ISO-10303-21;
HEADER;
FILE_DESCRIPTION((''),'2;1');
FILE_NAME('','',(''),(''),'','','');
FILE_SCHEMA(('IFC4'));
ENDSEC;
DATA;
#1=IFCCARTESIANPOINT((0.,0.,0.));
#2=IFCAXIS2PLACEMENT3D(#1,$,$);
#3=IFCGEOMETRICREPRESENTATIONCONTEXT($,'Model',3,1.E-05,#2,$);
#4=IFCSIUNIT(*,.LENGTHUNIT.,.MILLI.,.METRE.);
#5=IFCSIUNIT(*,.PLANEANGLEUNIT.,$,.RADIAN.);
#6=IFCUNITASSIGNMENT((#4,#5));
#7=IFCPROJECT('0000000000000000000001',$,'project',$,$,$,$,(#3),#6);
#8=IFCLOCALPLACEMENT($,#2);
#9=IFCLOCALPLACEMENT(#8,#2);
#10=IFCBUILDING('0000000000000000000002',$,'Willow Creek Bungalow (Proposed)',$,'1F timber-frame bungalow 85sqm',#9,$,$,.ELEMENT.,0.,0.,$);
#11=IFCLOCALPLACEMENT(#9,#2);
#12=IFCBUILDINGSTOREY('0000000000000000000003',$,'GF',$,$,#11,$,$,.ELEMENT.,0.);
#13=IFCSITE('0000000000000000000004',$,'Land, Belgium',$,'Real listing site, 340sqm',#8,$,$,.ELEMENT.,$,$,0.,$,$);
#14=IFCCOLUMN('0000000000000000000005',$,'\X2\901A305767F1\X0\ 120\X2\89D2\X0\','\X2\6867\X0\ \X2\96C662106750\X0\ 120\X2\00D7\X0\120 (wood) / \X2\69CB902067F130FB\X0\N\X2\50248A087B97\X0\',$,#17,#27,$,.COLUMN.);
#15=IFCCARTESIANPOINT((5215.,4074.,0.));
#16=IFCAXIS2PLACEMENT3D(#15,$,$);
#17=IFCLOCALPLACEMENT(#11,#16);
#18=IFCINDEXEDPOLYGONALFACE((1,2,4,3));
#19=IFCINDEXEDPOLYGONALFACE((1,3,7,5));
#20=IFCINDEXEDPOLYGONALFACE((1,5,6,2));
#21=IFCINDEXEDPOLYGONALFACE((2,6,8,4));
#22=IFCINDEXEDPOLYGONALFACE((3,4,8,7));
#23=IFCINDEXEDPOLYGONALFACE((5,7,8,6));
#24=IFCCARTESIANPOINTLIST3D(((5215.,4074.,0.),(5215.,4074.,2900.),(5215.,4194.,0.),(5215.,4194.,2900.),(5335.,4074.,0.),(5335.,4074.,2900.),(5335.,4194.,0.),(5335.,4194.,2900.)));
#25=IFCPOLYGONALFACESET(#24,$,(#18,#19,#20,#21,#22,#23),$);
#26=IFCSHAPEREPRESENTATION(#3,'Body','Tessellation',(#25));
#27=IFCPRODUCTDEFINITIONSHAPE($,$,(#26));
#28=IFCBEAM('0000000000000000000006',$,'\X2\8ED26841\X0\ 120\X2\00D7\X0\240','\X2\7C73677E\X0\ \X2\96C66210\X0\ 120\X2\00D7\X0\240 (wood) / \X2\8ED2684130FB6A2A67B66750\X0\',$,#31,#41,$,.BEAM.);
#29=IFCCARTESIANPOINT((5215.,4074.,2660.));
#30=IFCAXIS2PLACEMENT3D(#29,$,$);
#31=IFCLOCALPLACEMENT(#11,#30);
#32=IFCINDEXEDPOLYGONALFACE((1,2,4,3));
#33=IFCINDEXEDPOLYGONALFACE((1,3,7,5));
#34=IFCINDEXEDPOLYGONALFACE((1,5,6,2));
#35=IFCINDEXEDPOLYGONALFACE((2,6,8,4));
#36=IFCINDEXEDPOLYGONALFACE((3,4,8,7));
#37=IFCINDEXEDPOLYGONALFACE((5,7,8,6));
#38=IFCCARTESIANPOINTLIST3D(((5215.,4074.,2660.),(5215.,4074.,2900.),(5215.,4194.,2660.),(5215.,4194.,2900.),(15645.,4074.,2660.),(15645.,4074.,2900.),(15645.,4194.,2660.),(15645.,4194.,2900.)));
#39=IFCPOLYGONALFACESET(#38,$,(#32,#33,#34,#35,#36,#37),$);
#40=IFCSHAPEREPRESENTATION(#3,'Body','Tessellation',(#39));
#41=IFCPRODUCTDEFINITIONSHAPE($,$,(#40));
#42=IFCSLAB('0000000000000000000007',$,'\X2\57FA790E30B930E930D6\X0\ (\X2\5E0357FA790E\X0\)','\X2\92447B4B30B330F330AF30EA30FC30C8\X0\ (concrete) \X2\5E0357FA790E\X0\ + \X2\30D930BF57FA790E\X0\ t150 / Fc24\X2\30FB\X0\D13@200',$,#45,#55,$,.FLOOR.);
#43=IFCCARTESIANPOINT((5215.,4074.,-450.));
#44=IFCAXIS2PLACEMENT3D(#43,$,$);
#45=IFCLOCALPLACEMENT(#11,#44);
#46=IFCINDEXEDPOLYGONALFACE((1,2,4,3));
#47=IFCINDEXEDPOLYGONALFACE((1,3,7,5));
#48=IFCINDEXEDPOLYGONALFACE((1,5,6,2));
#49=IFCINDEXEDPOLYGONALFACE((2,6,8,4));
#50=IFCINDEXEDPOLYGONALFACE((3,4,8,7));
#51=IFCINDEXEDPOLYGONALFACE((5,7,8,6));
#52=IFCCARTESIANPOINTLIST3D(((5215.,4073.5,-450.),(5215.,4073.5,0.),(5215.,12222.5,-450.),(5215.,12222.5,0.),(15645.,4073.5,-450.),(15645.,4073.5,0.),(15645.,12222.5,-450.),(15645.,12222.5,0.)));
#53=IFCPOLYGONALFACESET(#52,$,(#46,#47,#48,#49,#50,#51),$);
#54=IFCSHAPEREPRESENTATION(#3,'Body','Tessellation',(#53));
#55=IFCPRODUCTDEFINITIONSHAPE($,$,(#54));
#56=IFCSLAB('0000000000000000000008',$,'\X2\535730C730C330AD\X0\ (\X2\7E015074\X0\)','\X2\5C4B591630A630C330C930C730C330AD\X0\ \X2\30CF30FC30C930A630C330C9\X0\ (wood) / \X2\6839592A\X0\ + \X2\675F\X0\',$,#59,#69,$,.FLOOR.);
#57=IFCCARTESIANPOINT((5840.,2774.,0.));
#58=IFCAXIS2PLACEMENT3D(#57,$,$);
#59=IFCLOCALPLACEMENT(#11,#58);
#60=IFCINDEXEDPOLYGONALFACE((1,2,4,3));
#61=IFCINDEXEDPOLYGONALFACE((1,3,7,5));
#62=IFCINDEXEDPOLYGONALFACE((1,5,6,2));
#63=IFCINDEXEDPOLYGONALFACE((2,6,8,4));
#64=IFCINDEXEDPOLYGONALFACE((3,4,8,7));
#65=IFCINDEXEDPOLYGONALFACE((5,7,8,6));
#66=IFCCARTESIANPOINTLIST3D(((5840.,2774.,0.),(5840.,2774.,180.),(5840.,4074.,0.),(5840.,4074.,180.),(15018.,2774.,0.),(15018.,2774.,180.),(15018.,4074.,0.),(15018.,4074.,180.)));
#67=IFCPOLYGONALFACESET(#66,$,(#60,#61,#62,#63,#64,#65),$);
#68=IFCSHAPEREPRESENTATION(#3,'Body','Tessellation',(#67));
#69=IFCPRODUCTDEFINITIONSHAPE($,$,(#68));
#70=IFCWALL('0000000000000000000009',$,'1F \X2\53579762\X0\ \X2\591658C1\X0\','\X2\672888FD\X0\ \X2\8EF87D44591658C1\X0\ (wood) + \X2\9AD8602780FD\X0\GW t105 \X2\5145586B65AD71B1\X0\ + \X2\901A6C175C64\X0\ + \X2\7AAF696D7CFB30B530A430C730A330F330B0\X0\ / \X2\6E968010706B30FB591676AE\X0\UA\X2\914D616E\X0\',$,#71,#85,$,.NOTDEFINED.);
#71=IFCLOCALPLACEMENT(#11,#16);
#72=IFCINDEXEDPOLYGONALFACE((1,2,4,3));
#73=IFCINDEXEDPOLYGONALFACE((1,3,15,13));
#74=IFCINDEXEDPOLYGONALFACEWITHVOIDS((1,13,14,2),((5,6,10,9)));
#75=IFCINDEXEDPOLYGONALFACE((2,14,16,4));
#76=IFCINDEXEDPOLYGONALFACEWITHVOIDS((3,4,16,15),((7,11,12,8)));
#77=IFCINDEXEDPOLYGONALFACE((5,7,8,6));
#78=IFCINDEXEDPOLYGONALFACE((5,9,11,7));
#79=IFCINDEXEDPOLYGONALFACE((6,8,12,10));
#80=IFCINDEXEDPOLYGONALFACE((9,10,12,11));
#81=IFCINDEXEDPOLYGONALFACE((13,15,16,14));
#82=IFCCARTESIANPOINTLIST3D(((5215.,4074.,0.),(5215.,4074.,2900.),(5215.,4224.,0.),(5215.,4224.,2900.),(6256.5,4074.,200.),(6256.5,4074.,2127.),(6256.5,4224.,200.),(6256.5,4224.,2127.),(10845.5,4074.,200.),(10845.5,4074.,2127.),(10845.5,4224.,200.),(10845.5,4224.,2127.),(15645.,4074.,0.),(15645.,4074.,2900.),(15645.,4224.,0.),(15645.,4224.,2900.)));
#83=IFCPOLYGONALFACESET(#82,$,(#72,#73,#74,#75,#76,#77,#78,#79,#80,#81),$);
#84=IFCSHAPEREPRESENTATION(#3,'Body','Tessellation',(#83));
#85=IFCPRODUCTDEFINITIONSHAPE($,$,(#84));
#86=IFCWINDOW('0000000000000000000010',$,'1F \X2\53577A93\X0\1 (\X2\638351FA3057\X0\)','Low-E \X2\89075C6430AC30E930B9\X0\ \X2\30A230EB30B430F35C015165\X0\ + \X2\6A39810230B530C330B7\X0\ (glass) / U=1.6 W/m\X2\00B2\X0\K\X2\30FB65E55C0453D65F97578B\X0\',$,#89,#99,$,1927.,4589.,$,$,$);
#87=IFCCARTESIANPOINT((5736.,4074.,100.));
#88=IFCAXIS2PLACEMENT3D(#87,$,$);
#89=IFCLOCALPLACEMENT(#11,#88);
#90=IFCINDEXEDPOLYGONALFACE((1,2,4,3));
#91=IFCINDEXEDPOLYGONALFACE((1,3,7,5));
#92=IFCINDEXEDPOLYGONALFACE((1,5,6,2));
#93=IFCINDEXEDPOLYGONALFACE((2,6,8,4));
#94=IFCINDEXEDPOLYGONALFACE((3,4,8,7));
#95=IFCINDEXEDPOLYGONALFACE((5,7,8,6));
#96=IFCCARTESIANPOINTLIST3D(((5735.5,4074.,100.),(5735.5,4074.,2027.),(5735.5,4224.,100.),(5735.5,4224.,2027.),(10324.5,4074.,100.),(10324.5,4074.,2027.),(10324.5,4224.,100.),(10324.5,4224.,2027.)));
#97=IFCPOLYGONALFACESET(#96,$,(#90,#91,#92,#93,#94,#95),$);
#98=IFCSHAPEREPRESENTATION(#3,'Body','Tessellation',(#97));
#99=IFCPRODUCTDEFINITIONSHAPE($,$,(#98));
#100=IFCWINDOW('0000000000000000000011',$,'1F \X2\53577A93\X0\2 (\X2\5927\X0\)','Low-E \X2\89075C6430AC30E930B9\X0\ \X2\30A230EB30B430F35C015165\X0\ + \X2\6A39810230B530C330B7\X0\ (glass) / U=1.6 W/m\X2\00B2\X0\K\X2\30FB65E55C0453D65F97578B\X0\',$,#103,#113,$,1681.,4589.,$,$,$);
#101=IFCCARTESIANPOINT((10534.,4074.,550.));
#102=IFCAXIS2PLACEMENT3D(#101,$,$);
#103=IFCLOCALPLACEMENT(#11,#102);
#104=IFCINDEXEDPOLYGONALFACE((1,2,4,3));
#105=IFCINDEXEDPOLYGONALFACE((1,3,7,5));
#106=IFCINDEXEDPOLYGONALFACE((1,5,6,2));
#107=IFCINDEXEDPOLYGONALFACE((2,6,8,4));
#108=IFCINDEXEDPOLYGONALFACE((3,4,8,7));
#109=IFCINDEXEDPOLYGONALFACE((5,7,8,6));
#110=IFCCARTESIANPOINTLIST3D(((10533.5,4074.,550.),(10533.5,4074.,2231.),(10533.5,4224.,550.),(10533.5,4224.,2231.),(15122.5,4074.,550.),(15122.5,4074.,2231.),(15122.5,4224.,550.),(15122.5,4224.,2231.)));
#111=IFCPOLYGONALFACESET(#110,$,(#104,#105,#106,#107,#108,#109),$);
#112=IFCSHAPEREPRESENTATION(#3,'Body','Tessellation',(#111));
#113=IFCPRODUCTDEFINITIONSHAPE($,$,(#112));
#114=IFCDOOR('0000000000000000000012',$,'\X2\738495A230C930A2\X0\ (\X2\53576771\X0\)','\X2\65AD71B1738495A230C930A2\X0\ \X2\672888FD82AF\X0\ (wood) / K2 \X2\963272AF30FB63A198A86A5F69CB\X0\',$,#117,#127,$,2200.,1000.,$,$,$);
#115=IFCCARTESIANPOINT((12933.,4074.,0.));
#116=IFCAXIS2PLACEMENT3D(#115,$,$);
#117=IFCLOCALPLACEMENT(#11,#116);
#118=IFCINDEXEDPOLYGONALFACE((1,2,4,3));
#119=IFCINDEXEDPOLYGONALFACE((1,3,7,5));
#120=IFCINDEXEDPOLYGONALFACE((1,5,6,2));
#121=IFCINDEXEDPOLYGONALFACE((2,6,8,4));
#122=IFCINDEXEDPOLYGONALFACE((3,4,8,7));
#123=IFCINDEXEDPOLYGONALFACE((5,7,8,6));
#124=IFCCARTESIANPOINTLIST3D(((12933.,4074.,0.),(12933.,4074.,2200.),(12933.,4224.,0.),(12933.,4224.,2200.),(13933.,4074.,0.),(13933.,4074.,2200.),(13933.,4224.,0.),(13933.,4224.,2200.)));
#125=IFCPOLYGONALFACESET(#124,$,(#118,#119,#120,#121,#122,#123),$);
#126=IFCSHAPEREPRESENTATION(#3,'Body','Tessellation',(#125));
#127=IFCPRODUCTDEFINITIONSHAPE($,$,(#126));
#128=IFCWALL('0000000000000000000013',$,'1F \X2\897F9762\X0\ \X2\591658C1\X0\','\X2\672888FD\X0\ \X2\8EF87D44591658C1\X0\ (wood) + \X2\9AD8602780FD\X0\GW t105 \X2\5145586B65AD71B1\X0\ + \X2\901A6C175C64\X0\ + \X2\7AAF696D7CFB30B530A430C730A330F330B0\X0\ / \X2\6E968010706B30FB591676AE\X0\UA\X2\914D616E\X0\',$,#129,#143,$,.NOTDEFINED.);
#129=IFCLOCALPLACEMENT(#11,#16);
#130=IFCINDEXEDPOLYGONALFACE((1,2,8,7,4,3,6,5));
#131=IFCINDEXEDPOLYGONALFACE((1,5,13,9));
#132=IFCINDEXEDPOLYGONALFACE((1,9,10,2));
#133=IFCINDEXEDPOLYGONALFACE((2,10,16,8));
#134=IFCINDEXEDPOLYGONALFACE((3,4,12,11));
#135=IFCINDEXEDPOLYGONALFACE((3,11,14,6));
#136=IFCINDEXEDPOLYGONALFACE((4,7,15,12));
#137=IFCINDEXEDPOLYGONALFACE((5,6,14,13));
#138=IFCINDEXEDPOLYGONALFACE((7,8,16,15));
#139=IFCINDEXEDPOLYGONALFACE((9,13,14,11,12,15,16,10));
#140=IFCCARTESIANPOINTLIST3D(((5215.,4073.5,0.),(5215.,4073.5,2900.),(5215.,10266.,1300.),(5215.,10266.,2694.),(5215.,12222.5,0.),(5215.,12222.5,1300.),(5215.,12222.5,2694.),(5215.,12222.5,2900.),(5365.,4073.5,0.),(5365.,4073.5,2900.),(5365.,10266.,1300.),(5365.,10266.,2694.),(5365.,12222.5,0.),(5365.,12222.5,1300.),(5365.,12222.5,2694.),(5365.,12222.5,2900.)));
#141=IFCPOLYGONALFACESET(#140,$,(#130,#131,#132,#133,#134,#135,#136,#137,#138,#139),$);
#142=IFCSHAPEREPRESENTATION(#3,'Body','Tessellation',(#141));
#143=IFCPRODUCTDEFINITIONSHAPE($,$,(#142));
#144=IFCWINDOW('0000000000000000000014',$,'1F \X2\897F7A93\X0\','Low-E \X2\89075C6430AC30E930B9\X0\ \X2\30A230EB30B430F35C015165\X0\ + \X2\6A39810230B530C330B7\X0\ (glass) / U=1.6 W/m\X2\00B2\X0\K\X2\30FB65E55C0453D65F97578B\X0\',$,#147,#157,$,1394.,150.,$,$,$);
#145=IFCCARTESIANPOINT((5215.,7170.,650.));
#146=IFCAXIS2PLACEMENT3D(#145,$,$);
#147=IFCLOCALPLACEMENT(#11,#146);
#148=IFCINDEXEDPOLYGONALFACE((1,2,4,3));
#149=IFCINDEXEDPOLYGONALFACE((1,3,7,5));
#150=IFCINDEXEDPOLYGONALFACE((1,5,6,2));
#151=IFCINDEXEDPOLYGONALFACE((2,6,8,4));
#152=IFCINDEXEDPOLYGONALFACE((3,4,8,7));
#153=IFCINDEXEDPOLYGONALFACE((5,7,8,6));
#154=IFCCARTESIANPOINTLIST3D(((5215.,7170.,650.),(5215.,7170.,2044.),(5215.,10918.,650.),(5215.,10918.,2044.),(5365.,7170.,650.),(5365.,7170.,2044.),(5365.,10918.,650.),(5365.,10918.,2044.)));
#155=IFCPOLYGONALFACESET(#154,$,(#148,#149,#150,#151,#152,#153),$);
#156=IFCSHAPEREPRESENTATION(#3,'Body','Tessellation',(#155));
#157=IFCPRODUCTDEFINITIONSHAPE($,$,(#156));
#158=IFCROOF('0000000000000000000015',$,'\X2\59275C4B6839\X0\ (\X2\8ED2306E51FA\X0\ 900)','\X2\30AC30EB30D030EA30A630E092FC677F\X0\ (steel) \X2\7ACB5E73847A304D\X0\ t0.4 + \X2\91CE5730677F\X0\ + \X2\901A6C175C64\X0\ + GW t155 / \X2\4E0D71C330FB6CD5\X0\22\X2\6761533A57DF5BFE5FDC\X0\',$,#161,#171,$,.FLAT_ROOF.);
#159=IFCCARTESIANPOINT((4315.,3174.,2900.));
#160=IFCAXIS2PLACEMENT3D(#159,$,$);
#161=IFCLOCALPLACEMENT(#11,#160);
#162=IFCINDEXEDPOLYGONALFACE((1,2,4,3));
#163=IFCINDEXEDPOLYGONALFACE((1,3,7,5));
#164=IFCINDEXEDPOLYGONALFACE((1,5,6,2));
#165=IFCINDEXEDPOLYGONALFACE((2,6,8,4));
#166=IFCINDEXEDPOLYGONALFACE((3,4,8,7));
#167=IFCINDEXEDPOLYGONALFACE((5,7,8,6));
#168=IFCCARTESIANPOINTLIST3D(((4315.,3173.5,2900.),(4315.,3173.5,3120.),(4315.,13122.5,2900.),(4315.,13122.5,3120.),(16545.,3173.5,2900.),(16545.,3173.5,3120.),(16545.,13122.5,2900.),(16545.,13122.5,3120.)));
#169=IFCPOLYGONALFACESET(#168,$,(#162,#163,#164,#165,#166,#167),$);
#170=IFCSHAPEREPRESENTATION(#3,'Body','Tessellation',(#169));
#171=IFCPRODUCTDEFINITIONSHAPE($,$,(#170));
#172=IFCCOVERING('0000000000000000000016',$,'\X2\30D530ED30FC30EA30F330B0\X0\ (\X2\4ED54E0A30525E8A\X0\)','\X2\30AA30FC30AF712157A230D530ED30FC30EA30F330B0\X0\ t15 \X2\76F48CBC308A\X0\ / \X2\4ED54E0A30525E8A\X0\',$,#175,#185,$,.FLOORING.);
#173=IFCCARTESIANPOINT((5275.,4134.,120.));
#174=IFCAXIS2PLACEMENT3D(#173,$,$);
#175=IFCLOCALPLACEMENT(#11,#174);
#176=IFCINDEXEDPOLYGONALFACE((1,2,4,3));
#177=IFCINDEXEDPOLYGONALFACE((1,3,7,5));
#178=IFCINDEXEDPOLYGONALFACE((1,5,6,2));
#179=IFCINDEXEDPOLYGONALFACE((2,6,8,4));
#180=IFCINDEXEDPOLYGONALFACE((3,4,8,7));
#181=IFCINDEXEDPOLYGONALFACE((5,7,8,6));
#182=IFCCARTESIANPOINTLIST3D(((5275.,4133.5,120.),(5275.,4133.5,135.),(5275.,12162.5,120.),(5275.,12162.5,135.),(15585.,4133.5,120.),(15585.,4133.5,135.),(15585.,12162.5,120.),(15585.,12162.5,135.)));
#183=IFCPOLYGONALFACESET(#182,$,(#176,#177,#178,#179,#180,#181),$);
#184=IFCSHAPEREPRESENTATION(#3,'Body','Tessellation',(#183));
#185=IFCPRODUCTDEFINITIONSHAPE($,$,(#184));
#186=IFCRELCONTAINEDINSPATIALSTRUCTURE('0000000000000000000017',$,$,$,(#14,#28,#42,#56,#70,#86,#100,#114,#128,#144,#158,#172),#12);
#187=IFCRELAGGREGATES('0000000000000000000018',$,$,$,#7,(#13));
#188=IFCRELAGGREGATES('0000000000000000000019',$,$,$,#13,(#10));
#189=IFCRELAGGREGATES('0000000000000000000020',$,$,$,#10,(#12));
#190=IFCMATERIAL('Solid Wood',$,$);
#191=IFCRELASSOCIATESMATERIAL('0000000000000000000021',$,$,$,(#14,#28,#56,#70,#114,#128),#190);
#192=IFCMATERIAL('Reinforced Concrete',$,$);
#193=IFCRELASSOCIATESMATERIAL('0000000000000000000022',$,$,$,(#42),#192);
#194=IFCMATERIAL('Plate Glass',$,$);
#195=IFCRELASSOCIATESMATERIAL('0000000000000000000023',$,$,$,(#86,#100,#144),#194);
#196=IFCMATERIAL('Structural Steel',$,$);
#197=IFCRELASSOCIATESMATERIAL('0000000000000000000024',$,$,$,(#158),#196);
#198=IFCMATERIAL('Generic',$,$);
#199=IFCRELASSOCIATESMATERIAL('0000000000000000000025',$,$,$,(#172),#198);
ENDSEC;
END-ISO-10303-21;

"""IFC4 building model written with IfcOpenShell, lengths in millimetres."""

from ifc_helpers import new_model, si_unit, frame, frame_2d, origin, place, context, project, spatial, rectangle, extrude, material, element, fill, save


model = new_model("IFC4")

# Units and contexts
model_context = context("Model", 3, precision=1e-05, world=origin())
ifc_project = project(units=[si_unit("LENGTHUNIT", "METRE", prefix="MILLI"), si_unit("PLANEANGLEUNIT", "RADIAN")], contexts=[model_context])

# Site, building, storey
site_placement = place(None, origin())
site = spatial("IfcSite", under=ifc_project, at=site_placement, Name="Land, Belgium", ObjectType="Real listing site, 340sqm", CompositionType="ELEMENT", RefElevation=0.0)
building_placement = place(site_placement, origin())
building = spatial("IfcBuilding", under=site, at=building_placement, Name="Willow Creek Bungalow (Proposed)", ObjectType="1F timber-frame bungalow 85sqm", CompositionType="ELEMENT", ElevationOfRefHeight=0.0, ElevationOfTerrain=0.0)
storey_placement = place(building_placement, origin())
storey = spatial("IfcBuildingStorey", under=building, at=storey_placement, Name="GF", CompositionType="ELEMENT", Elevation=0.0)

# Column
ifc_material_1 = material(Name="Solid Wood")
column_1_placement = place(storey_placement, frame((5215.0, 4074.0, 0.0)))
element("IfcColumn", 1, at=column_1_placement, inside=storey, material=ifc_material_1, Name="通し柱 120角", Description="桧 集成材 120×120 (wood) / 構造柱・N値計算", PredefinedType="COLUMN", context=model_context, shape_type="SweptSolid", body=[
    extrude(rectangle(XDim=120.0, YDim=120.0, at=frame_2d((60.0, 60.0))), frame((5215.0, 4074.0, 0.0)), (0.0, 0.0, 1.0), 2900.0),
])

# Beam
beam_1_placement = place(storey_placement, frame((5215.0, 4074.0, 2660.0)))
element("IfcBeam", 2, at=beam_1_placement, inside=storey, material=ifc_material_1, Name="軒桁 120×240", Description="米松 集成 120×240 (wood) / 軒桁・横架材", PredefinedType="BEAM", context=model_context, shape_type="SweptSolid", body=[
    extrude(rectangle(XDim=10430.0, YDim=120.0, at=frame_2d((5215.0, 60.0))), frame((5215.0, 4074.0, 2660.0)), (0.0, 0.0, 1.0), 240.0),
])

# Slabs
ifc_material_2 = material(Name="Reinforced Concrete")
slab_1_placement = place(storey_placement, frame((5215.0, 4074.0, -450.0)))
element("IfcSlab", 3, at=slab_1_placement, inside=storey, material=ifc_material_2, Name="基礎スラブ (布基礎)", Description="鉄筋コンクリート (concrete) 布基礎 + ベタ基礎 t150 / Fc24・D13@200", PredefinedType="FLOOR", context=model_context, shape_type="SweptSolid", body=[
    extrude(rectangle(XDim=10430.0, YDim=8149.0, at=frame_2d((5215.0, 4074.0))), frame((5215.0, 4074.0, -450.0)), (0.0, 0.0, 1.0), 450.0),
])
slab_2_placement = place(storey_placement, frame((5840.0, 2774.0, 0.0)))
element("IfcSlab", 4, at=slab_2_placement, inside=storey, material=ifc_material_1, Name="南デッキ (縁側)", Description="屋外ウッドデッキ ハードウッド (wood) / 根太 + 束", PredefinedType="FLOOR", context=model_context, shape_type="SweptSolid", body=[
    extrude(rectangle(XDim=9178.0, YDim=1300.0, at=frame_2d((4589.0, 650.0))), frame((5840.0, 2774.0, 0.0)), (0.0, 0.0, 1.0), 180.0),
])

# Wall, openings, windows, door
wall_1_placement = place(storey_placement, frame((5215.0, 4074.0, 0.0)))
wall_1 = element("IfcWall", 5, at=wall_1_placement, inside=storey, material=ifc_material_1, Name="1F 南面 外壁", Description="木製 軸組外壁 (wood) + 高性能GW t105 充填断熱 + 通気層 + 窯業系サイディング / 準耐火・外皮UA配慮", PredefinedType="NOTDEFINED", context=model_context, shape_type="SweptSolid", body=[
    extrude(rectangle(XDim=10430.0, YDim=150.0, at=frame_2d((5215.0, 75.0))), frame((5215.0, 4074.0, 0.0)), (0.0, 0.0, 1.0), 2900.0),
])
opening_1_placement = place(storey_placement, frame((5736.0, 4074.0, 100.0)))
opening_1 = element("IfcOpeningElement", 6, at=opening_1_placement, cuts=wall_1, PredefinedType="NOTDEFINED", context=model_context, shape_type="SweptSolid", body=[
    extrude(rectangle(XDim=4589.0, YDim=150.0, at=frame_2d((2294.0, 75.0))), frame((5736.0, 4074.0, 100.0)), (0.0, 0.0, 1.0), 1927.0),
])
opening_2_placement = place(storey_placement, frame((10534.0, 4074.0, 550.0)))
opening_2 = element("IfcOpeningElement", 7, at=opening_2_placement, cuts=wall_1, PredefinedType="NOTDEFINED", context=model_context, shape_type="SweptSolid", body=[
    extrude(rectangle(XDim=4589.0, YDim=150.0, at=frame_2d((2294.0, 75.0))), frame((10534.0, 4074.0, 550.0)), (0.0, 0.0, 1.0), 1681.0),
])
opening_3_placement = place(storey_placement, frame((12933.0, 4074.0, 0.0)))
opening_3 = element("IfcOpeningElement", 8, at=opening_3_placement, cuts=wall_1, PredefinedType="NOTDEFINED", context=model_context, shape_type="SweptSolid", body=[
    extrude(rectangle(XDim=1000.0, YDim=150.0, at=frame_2d((500.0, 75.0))), frame((12933.0, 4074.0, 0.0)), (0.0, 0.0, 1.0), 2200.0),
])
ifc_material_3 = material(Name="Plate Glass")
window_1_placement = place(storey_placement, frame((5736.0, 4074.0, 100.0)))
window_1 = element("IfcWindow", 9, at=window_1_placement, inside=storey, material=ifc_material_3, Name="1F 南窓1 (掃出し)", Description="Low-E 複層ガラス アルゴン封入 + 樹脂サッシ (glass) / U=1.6 W/m²K・日射取得型", OverallHeight=1927.0, OverallWidth=4589.0, context=model_context, shape_type="SweptSolid", body=[
    extrude(rectangle(XDim=4589.0, YDim=150.0, at=frame_2d((2294.0, 75.0))), frame((5736.0, 4074.0, 100.0)), (0.0, 0.0, 1.0), 1927.0),
])
fill(opening_1, window_1)
window_2_placement = place(storey_placement, frame((10534.0, 4074.0, 550.0)))
window_2 = element("IfcWindow", 10, at=window_2_placement, inside=storey, material=ifc_material_3, Name="1F 南窓2 (大)", Description="Low-E 複層ガラス アルゴン封入 + 樹脂サッシ (glass) / U=1.6 W/m²K・日射取得型", OverallHeight=1681.0, OverallWidth=4589.0, context=model_context, shape_type="SweptSolid", body=[
    extrude(rectangle(XDim=4589.0, YDim=150.0, at=frame_2d((2294.0, 75.0))), frame((10534.0, 4074.0, 550.0)), (0.0, 0.0, 1.0), 1681.0),
])
fill(opening_2, window_2)
door_placement = place(storey_placement, frame((12933.0, 4074.0, 0.0)))
door = element("IfcDoor", 11, at=door_placement, inside=storey, material=ifc_material_1, Name="玄関ドア (南東)", Description="断熱玄関ドア 木製芯 (wood) / K2 防犯・採風機構", OverallHeight=2200.0, OverallWidth=1000.0, context=model_context, shape_type="SweptSolid", body=[
    extrude(rectangle(XDim=1000.0, YDim=150.0, at=frame_2d((500.0, 75.0))), frame((12933.0, 4074.0, 0.0)), (0.0, 0.0, 1.0), 2200.0),
])
fill(opening_3, door)

# Wall, opening, window
wall_2_placement = place(storey_placement, frame((5215.0, 4074.0, 0.0)))
wall_2 = element("IfcWall", 12, at=wall_2_placement, inside=storey, material=ifc_material_1, Name="1F 西面 外壁", Description="木製 軸組外壁 (wood) + 高性能GW t105 充填断熱 + 通気層 + 窯業系サイディング / 準耐火・外皮UA配慮", PredefinedType="NOTDEFINED", context=model_context, shape_type="SweptSolid", body=[
    extrude(rectangle(XDim=150.0, YDim=8149.0, at=frame_2d((75.0, 4074.0))), frame((5215.0, 4074.0, 0.0)), (0.0, 0.0, 1.0), 2900.0),
])
opening_4_placement = place(storey_placement, frame((5215.0, 7170.0, 650.0)))
opening_4 = element("IfcOpeningElement", 13, at=opening_4_placement, cuts=wall_2, PredefinedType="NOTDEFINED", context=model_context, shape_type="SweptSolid", body=[
    extrude(rectangle(XDim=150.0, YDim=3748.0, at=frame_2d((75.0, 1874.0))), frame((5215.0, 7170.0, 650.0)), (0.0, 0.0, 1.0), 1394.0),
])
window_3_placement = place(storey_placement, frame((5215.0, 7170.0, 650.0)))
window_3 = element("IfcWindow", 14, at=window_3_placement, inside=storey, material=ifc_material_3, Name="1F 西窓", Description="Low-E 複層ガラス アルゴン封入 + 樹脂サッシ (glass) / U=1.6 W/m²K・日射取得型", OverallHeight=1394.0, OverallWidth=150.0, context=model_context, shape_type="SweptSolid", body=[
    extrude(rectangle(XDim=150.0, YDim=3748.0, at=frame_2d((75.0, 1874.0))), frame((5215.0, 7170.0, 650.0)), (0.0, 0.0, 1.0), 1394.0),
])
fill(opening_4, window_3)

# Roof
ifc_material_4 = material(Name="Structural Steel")
roof_placement = place(storey_placement, frame((4315.0, 3174.0, 2900.0)))
element("IfcRoof", 15, at=roof_placement, inside=storey, material=ifc_material_4, Name="大屋根 (軒の出 900)", Description="ガルバリウム鋼板 (steel) 立平葺き t0.4 + 野地板 + 通気層 + GW t155 / 不燃・法22条区域対応", PredefinedType="FLAT_ROOF", context=model_context, shape_type="SweptSolid", body=[
    extrude(rectangle(XDim=12230.0, YDim=9949.0, at=frame_2d((6115.0, 4974.0))), frame((4315.0, 3174.0, 2900.0)), (0.0, 0.0, 1.0), 220.0),
])

# Covering
ifc_material_5 = material(Name="Generic")
covering_1_placement = place(storey_placement, frame((5275.0, 4134.0, 120.0)))
element("IfcCovering", 16, at=covering_1_placement, inside=storey, material=ifc_material_5, Name="フローリング (仕上げ床)", Description="オーク無垢フローリング t15 直貼り / 仕上げ床", PredefinedType="FLOORING", context=model_context, shape_type="SweptSolid", body=[
    extrude(rectangle(XDim=10310.0, YDim=8029.0, at=frame_2d((5155.0, 4014.0))), frame((5275.0, 4134.0, 120.0)), (0.0, 0.0, 1.0), 15.0),
])

save(model, "model.ifc")
